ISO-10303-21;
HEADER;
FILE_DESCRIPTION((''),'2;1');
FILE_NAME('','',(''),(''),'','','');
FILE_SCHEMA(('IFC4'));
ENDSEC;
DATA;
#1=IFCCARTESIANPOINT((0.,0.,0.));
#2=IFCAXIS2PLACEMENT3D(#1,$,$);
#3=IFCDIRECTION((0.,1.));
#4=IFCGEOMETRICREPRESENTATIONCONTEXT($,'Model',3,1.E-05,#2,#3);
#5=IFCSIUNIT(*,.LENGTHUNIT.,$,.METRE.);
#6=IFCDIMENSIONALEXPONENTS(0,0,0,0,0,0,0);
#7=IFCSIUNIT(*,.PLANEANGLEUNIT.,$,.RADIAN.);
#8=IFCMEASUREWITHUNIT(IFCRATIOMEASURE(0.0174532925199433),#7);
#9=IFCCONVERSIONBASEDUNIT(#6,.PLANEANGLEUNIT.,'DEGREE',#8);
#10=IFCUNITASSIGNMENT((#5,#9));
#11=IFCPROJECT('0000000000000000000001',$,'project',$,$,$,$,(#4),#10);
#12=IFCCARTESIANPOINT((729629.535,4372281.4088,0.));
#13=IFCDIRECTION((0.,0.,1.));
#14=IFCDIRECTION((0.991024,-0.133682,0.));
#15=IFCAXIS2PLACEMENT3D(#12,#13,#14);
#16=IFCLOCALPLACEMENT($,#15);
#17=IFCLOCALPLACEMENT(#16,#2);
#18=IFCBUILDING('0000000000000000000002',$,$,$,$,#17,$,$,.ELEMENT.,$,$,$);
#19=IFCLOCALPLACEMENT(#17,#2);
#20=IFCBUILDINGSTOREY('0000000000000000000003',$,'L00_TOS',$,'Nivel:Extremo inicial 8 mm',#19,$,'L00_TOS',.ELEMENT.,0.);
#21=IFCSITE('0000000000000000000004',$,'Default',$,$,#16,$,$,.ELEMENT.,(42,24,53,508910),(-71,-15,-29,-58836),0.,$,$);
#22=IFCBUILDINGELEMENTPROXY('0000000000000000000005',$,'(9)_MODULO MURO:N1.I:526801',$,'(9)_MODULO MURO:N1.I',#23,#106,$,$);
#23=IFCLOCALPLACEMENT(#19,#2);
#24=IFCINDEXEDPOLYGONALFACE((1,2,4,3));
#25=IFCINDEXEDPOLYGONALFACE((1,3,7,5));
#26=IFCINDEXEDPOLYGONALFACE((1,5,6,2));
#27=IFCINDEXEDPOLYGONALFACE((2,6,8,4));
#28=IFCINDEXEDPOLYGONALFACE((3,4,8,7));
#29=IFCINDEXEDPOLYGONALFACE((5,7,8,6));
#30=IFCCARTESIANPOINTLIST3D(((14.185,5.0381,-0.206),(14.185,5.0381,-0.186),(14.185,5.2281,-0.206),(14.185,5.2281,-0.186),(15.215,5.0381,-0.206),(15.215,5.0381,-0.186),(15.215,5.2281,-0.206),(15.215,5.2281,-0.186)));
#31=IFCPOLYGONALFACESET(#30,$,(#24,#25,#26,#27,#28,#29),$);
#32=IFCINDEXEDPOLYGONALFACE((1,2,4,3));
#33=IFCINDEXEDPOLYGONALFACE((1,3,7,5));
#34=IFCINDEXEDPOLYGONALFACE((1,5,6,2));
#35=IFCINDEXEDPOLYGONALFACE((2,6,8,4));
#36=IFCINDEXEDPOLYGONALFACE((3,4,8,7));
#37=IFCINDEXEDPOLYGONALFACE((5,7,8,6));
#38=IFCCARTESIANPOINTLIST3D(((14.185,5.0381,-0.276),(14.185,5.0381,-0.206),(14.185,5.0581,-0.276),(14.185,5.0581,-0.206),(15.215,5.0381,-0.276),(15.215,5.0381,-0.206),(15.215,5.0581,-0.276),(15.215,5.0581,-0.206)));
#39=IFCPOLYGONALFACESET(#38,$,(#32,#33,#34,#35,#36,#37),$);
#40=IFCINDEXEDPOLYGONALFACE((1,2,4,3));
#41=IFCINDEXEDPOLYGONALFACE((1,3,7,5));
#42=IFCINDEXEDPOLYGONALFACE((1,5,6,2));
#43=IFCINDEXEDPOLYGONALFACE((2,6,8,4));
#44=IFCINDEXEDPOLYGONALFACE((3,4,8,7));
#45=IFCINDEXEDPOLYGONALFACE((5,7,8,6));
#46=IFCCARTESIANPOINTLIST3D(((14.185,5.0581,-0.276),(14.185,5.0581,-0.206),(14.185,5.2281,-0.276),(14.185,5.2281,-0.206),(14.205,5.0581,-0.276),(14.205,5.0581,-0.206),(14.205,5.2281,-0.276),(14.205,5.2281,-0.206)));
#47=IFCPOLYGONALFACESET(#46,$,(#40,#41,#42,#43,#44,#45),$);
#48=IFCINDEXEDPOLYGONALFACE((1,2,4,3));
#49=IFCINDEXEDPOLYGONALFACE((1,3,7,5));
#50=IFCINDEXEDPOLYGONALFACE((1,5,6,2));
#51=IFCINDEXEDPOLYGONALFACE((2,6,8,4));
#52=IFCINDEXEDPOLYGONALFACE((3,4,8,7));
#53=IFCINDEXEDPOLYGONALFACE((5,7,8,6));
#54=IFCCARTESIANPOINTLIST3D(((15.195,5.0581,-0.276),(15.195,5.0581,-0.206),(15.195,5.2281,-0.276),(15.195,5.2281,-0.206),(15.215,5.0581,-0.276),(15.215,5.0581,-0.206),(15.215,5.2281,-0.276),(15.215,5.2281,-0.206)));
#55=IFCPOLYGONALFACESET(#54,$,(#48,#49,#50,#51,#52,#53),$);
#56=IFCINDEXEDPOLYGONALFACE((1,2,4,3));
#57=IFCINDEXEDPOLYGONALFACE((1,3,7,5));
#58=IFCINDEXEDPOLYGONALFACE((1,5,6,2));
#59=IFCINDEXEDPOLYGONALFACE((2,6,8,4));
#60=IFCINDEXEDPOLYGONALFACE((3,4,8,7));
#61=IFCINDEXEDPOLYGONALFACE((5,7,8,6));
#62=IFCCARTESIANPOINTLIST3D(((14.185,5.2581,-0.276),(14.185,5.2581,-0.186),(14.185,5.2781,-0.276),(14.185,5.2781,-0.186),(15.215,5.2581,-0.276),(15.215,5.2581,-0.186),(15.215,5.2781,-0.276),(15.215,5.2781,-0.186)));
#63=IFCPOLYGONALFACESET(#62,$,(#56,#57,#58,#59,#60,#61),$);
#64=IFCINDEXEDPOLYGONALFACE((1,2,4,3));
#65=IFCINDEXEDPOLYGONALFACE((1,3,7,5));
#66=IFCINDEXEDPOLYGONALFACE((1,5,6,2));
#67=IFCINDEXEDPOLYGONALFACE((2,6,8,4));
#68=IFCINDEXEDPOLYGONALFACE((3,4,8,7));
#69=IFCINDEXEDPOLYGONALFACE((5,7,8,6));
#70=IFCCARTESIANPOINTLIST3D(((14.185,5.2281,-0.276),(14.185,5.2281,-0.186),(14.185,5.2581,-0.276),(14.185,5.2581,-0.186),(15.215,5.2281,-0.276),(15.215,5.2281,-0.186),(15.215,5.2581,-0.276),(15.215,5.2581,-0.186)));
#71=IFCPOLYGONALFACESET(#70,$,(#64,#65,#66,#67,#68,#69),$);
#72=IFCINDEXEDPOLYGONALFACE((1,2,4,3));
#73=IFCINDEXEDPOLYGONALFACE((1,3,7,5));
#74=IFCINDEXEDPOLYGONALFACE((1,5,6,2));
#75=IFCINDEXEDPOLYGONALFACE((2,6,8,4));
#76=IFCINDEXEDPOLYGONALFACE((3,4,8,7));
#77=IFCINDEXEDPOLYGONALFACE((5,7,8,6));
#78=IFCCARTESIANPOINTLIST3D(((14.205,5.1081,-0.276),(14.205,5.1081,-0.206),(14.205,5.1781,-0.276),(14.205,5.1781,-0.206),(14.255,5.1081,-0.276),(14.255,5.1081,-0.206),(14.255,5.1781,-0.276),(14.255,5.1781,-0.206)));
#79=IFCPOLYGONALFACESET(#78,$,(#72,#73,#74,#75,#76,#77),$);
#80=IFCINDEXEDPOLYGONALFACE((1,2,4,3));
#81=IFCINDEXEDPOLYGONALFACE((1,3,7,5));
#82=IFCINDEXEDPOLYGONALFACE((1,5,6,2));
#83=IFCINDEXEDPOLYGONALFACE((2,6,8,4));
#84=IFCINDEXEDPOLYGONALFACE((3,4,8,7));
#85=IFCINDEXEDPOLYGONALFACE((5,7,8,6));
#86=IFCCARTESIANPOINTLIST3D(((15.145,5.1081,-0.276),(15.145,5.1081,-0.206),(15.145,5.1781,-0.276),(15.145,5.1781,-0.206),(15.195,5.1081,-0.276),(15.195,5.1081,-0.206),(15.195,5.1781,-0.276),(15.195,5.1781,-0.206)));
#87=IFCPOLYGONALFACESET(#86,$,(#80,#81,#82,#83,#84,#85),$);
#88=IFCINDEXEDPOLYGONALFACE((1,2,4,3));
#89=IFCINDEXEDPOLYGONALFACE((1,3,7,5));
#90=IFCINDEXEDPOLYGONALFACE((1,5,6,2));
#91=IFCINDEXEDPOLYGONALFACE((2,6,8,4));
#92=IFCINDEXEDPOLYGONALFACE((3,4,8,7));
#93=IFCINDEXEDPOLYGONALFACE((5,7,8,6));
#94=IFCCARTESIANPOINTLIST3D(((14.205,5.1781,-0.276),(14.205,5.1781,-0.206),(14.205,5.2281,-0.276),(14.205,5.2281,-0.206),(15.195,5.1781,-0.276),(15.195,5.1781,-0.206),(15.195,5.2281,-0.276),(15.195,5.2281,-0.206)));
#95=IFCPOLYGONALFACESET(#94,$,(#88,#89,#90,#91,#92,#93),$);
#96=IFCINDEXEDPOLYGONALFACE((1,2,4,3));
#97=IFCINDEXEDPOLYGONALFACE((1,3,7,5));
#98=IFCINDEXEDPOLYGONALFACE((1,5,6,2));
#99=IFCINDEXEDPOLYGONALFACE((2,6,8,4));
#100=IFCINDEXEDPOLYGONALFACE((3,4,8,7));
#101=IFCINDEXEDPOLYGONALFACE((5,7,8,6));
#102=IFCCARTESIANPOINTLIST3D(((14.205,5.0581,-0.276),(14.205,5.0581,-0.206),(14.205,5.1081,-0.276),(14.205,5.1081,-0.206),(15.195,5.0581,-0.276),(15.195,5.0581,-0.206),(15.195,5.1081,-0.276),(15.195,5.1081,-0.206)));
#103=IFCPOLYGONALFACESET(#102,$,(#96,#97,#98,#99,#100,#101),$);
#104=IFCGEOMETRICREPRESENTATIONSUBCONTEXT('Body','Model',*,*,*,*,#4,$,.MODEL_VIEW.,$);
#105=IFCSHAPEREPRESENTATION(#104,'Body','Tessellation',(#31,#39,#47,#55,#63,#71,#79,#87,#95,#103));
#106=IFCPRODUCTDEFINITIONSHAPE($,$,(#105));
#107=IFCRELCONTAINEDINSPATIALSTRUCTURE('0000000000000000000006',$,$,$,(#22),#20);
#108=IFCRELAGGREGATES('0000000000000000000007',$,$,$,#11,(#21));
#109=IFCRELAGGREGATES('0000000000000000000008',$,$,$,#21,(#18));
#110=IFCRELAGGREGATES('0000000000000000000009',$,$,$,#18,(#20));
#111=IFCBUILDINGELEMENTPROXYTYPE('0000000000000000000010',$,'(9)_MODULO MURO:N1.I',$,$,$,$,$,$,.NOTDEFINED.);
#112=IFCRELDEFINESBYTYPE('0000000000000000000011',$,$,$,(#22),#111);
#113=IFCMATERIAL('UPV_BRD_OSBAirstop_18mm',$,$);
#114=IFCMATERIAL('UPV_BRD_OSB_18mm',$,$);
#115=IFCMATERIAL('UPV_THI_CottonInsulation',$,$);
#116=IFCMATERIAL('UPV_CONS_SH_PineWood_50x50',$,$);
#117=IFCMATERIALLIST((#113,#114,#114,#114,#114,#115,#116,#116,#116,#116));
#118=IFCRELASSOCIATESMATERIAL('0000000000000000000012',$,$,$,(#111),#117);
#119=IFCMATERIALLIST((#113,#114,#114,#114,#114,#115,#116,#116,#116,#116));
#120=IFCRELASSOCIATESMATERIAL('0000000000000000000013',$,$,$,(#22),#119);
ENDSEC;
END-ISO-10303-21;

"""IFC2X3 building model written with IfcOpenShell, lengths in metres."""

from ifc_helpers import new_model, entity, si_unit, converted_unit, direction, frame, frame_2d, origin, origin_2d_with_axis, place, context, subcontext, project, spatial, rectangle, extrude, source, transform, mapped, material, material_list, type_object, type_shapes, element, save


model = new_model("IFC2X3")

# Units and contexts
model_context = context("Model", 3, precision=1e-05, world=origin(), true_north=direction((0.0, 1.0)))
body_context = subcontext(model_context, "Body", "Model", "MODEL_VIEW")
ifc_project = project(units=[si_unit("LENGTHUNIT", "METRE"), converted_unit("PLANEANGLEUNIT", "DEGREE", entity("IfcRatioMeasure", 0.0174532925199433), si_unit("PLANEANGLEUNIT", "RADIAN"), dimensions=[0, 0, 0, 0, 0, 0, 0])], contexts=[model_context])

# Site, building, storey
site_placement = place(None, frame((729629.535, 4372281.4088, 0.0), z_axis=(0.0, 0.0, 1.0), x_axis=(0.991024, -0.133682, 0.0)))
site = spatial("IfcSite", under=ifc_project, at=site_placement, Name="Default", CompositionType="ELEMENT", RefLatitude=(42, 24, 53, 508910), RefLongitude=(-71, -15, -29, -58836), RefElevation=0.0)
building_placement = place(site_placement, origin())
building = spatial("IfcBuilding", under=site, at=building_placement, CompositionType="ELEMENT")
storey_placement = place(building_placement, origin())
storey = spatial("IfcBuildingStorey", under=building, at=storey_placement, Name="L00_TOS", ObjectType="Nivel:Extremo inicial 8 mm", LongName="L00_TOS", CompositionType="ELEMENT", Elevation=0.0)

# Building element proxy
ifc_material_1 = material(Name="UPV_BRD_OSBAirstop_18mm")
ifc_material_2 = material(Name="UPV_BRD_OSB_18mm")
ifc_material_3 = material(Name="UPV_THI_CottonInsulation")
ifc_material_4 = material(Name="UPV_CONS_SH_PineWood_50x50")
ifc_material_list_1 = material_list([ifc_material_1, ifc_material_2, ifc_material_2, ifc_material_2, ifc_material_2, ifc_material_3, ifc_material_4, ifc_material_4, ifc_material_4, ifc_material_4])
ifc_material_list_2 = material_list([ifc_material_1, ifc_material_2, ifc_material_2, ifc_material_2, ifc_material_2, ifc_material_3, ifc_material_4, ifc_material_4, ifc_material_4, ifc_material_4])
building_element_proxy_type_1 = type_object("IfcBuildingElementProxyType", Name="(9)_MODULO MURO:N1.I", PredefinedType="NOTDEFINED", material=ifc_material_list_2)
shared_shape_1 = source(origin(), body_context, "Body", "SweptSolid", [
    extrude(rectangle(XDim=1.03, YDim=0.19, at=origin_2d_with_axis()), frame((0.0, -0.01, 0.07)), (0.0, 0.0, 1.0), 0.02),
    extrude(rectangle(XDim=1.03, YDim=0.02, at=frame_2d((0.0, 0.0), x_axis=(1.0, 0.0))), frame((0.0, -0.095, 0.0), z_axis=(0.0, 0.0, 1.0), x_axis=(-1.0, 0.0, 0.0)), (0.0, 0.0, 1.0), 0.07),
    extrude(rectangle(XDim=0.17, YDim=0.02, at=frame_2d((0.0, 0.0), x_axis=(1.0, 0.0))), frame((-0.505, 0.0, 0.0), z_axis=(0.0, 0.0, 1.0), x_axis=(0.0, -1.0, 0.0)), (0.0, 0.0, 1.0), 0.07),
    extrude(rectangle(XDim=0.17, YDim=0.02, at=origin_2d_with_axis()), frame((0.505, 0.0, 0.0), z_axis=(0.0, 0.0, 1.0), x_axis=(0.0, -1.0, 0.0)), (0.0, 0.0, 1.0), 0.07),
    extrude(rectangle(XDim=1.03, YDim=0.02, at=frame_2d((0.0, 0.0), x_axis=(1.0, 0.0))), frame((0.0, 0.125, 0.0), z_axis=(0.0, 0.0, 1.0), x_axis=(-1.0, 0.0, 0.0)), (0.0, 0.0, 1.0), 0.09),
    extrude(rectangle(XDim=1.03, YDim=0.03, at=origin_2d_with_axis()), frame((0.0, 0.1, 0.0)), (0.0, 0.0, 1.0), 0.09),
    extrude(rectangle(XDim=0.07, YDim=0.05, at=frame_2d((0.0, 0.0), x_axis=(1.0, 0.0))), frame((-0.47, 0.0, 0.0), z_axis=(0.0, 0.0, 1.0), x_axis=(0.0, -1.0, 0.0)), (0.0, 0.0, 1.0), 0.07),
    extrude(rectangle(XDim=0.07, YDim=0.05, at=origin_2d_with_axis()), frame((0.47, 0.0, 0.0), z_axis=(0.0, 0.0, 1.0), x_axis=(0.0, -1.0, 0.0)), (0.0, 0.0, 1.0), 0.07),
    extrude(rectangle(XDim=0.05, YDim=0.99, at=origin_2d_with_axis()), frame((0.0, 0.06, 0.0), z_axis=(0.0, 0.0, 1.0), x_axis=(0.0, -1.0, 0.0)), (0.0, 0.0, 1.0), 0.07),
    extrude(rectangle(XDim=0.05, YDim=0.99, at=origin_2d_with_axis()), frame((0.0, -0.06, 0.0), z_axis=(0.0, 0.0, 1.0), x_axis=(0.0, -1.0, 0.0)), (0.0, 0.0, 1.0), 0.07),
])
type_shapes(building_element_proxy_type_1, [shared_shape_1])
proxy_1_placement = place(storey_placement, frame((14.7, 5.1431, -0.276)))
element("IfcBuildingElementProxy", 1, at=proxy_1_placement, inside=storey, type_object=building_element_proxy_type_1, material=ifc_material_list_1, Name="(9)_MODULO MURO:N1.I:526801", ObjectType="(9)_MODULO MURO:N1.I", context=body_context, shape_type="MappedRepresentation", body=[
    mapped(shared_shape_1, transform((0.0, 0.0, 0.0), scale=1.0)),
])

save(model, "model.ifc")
